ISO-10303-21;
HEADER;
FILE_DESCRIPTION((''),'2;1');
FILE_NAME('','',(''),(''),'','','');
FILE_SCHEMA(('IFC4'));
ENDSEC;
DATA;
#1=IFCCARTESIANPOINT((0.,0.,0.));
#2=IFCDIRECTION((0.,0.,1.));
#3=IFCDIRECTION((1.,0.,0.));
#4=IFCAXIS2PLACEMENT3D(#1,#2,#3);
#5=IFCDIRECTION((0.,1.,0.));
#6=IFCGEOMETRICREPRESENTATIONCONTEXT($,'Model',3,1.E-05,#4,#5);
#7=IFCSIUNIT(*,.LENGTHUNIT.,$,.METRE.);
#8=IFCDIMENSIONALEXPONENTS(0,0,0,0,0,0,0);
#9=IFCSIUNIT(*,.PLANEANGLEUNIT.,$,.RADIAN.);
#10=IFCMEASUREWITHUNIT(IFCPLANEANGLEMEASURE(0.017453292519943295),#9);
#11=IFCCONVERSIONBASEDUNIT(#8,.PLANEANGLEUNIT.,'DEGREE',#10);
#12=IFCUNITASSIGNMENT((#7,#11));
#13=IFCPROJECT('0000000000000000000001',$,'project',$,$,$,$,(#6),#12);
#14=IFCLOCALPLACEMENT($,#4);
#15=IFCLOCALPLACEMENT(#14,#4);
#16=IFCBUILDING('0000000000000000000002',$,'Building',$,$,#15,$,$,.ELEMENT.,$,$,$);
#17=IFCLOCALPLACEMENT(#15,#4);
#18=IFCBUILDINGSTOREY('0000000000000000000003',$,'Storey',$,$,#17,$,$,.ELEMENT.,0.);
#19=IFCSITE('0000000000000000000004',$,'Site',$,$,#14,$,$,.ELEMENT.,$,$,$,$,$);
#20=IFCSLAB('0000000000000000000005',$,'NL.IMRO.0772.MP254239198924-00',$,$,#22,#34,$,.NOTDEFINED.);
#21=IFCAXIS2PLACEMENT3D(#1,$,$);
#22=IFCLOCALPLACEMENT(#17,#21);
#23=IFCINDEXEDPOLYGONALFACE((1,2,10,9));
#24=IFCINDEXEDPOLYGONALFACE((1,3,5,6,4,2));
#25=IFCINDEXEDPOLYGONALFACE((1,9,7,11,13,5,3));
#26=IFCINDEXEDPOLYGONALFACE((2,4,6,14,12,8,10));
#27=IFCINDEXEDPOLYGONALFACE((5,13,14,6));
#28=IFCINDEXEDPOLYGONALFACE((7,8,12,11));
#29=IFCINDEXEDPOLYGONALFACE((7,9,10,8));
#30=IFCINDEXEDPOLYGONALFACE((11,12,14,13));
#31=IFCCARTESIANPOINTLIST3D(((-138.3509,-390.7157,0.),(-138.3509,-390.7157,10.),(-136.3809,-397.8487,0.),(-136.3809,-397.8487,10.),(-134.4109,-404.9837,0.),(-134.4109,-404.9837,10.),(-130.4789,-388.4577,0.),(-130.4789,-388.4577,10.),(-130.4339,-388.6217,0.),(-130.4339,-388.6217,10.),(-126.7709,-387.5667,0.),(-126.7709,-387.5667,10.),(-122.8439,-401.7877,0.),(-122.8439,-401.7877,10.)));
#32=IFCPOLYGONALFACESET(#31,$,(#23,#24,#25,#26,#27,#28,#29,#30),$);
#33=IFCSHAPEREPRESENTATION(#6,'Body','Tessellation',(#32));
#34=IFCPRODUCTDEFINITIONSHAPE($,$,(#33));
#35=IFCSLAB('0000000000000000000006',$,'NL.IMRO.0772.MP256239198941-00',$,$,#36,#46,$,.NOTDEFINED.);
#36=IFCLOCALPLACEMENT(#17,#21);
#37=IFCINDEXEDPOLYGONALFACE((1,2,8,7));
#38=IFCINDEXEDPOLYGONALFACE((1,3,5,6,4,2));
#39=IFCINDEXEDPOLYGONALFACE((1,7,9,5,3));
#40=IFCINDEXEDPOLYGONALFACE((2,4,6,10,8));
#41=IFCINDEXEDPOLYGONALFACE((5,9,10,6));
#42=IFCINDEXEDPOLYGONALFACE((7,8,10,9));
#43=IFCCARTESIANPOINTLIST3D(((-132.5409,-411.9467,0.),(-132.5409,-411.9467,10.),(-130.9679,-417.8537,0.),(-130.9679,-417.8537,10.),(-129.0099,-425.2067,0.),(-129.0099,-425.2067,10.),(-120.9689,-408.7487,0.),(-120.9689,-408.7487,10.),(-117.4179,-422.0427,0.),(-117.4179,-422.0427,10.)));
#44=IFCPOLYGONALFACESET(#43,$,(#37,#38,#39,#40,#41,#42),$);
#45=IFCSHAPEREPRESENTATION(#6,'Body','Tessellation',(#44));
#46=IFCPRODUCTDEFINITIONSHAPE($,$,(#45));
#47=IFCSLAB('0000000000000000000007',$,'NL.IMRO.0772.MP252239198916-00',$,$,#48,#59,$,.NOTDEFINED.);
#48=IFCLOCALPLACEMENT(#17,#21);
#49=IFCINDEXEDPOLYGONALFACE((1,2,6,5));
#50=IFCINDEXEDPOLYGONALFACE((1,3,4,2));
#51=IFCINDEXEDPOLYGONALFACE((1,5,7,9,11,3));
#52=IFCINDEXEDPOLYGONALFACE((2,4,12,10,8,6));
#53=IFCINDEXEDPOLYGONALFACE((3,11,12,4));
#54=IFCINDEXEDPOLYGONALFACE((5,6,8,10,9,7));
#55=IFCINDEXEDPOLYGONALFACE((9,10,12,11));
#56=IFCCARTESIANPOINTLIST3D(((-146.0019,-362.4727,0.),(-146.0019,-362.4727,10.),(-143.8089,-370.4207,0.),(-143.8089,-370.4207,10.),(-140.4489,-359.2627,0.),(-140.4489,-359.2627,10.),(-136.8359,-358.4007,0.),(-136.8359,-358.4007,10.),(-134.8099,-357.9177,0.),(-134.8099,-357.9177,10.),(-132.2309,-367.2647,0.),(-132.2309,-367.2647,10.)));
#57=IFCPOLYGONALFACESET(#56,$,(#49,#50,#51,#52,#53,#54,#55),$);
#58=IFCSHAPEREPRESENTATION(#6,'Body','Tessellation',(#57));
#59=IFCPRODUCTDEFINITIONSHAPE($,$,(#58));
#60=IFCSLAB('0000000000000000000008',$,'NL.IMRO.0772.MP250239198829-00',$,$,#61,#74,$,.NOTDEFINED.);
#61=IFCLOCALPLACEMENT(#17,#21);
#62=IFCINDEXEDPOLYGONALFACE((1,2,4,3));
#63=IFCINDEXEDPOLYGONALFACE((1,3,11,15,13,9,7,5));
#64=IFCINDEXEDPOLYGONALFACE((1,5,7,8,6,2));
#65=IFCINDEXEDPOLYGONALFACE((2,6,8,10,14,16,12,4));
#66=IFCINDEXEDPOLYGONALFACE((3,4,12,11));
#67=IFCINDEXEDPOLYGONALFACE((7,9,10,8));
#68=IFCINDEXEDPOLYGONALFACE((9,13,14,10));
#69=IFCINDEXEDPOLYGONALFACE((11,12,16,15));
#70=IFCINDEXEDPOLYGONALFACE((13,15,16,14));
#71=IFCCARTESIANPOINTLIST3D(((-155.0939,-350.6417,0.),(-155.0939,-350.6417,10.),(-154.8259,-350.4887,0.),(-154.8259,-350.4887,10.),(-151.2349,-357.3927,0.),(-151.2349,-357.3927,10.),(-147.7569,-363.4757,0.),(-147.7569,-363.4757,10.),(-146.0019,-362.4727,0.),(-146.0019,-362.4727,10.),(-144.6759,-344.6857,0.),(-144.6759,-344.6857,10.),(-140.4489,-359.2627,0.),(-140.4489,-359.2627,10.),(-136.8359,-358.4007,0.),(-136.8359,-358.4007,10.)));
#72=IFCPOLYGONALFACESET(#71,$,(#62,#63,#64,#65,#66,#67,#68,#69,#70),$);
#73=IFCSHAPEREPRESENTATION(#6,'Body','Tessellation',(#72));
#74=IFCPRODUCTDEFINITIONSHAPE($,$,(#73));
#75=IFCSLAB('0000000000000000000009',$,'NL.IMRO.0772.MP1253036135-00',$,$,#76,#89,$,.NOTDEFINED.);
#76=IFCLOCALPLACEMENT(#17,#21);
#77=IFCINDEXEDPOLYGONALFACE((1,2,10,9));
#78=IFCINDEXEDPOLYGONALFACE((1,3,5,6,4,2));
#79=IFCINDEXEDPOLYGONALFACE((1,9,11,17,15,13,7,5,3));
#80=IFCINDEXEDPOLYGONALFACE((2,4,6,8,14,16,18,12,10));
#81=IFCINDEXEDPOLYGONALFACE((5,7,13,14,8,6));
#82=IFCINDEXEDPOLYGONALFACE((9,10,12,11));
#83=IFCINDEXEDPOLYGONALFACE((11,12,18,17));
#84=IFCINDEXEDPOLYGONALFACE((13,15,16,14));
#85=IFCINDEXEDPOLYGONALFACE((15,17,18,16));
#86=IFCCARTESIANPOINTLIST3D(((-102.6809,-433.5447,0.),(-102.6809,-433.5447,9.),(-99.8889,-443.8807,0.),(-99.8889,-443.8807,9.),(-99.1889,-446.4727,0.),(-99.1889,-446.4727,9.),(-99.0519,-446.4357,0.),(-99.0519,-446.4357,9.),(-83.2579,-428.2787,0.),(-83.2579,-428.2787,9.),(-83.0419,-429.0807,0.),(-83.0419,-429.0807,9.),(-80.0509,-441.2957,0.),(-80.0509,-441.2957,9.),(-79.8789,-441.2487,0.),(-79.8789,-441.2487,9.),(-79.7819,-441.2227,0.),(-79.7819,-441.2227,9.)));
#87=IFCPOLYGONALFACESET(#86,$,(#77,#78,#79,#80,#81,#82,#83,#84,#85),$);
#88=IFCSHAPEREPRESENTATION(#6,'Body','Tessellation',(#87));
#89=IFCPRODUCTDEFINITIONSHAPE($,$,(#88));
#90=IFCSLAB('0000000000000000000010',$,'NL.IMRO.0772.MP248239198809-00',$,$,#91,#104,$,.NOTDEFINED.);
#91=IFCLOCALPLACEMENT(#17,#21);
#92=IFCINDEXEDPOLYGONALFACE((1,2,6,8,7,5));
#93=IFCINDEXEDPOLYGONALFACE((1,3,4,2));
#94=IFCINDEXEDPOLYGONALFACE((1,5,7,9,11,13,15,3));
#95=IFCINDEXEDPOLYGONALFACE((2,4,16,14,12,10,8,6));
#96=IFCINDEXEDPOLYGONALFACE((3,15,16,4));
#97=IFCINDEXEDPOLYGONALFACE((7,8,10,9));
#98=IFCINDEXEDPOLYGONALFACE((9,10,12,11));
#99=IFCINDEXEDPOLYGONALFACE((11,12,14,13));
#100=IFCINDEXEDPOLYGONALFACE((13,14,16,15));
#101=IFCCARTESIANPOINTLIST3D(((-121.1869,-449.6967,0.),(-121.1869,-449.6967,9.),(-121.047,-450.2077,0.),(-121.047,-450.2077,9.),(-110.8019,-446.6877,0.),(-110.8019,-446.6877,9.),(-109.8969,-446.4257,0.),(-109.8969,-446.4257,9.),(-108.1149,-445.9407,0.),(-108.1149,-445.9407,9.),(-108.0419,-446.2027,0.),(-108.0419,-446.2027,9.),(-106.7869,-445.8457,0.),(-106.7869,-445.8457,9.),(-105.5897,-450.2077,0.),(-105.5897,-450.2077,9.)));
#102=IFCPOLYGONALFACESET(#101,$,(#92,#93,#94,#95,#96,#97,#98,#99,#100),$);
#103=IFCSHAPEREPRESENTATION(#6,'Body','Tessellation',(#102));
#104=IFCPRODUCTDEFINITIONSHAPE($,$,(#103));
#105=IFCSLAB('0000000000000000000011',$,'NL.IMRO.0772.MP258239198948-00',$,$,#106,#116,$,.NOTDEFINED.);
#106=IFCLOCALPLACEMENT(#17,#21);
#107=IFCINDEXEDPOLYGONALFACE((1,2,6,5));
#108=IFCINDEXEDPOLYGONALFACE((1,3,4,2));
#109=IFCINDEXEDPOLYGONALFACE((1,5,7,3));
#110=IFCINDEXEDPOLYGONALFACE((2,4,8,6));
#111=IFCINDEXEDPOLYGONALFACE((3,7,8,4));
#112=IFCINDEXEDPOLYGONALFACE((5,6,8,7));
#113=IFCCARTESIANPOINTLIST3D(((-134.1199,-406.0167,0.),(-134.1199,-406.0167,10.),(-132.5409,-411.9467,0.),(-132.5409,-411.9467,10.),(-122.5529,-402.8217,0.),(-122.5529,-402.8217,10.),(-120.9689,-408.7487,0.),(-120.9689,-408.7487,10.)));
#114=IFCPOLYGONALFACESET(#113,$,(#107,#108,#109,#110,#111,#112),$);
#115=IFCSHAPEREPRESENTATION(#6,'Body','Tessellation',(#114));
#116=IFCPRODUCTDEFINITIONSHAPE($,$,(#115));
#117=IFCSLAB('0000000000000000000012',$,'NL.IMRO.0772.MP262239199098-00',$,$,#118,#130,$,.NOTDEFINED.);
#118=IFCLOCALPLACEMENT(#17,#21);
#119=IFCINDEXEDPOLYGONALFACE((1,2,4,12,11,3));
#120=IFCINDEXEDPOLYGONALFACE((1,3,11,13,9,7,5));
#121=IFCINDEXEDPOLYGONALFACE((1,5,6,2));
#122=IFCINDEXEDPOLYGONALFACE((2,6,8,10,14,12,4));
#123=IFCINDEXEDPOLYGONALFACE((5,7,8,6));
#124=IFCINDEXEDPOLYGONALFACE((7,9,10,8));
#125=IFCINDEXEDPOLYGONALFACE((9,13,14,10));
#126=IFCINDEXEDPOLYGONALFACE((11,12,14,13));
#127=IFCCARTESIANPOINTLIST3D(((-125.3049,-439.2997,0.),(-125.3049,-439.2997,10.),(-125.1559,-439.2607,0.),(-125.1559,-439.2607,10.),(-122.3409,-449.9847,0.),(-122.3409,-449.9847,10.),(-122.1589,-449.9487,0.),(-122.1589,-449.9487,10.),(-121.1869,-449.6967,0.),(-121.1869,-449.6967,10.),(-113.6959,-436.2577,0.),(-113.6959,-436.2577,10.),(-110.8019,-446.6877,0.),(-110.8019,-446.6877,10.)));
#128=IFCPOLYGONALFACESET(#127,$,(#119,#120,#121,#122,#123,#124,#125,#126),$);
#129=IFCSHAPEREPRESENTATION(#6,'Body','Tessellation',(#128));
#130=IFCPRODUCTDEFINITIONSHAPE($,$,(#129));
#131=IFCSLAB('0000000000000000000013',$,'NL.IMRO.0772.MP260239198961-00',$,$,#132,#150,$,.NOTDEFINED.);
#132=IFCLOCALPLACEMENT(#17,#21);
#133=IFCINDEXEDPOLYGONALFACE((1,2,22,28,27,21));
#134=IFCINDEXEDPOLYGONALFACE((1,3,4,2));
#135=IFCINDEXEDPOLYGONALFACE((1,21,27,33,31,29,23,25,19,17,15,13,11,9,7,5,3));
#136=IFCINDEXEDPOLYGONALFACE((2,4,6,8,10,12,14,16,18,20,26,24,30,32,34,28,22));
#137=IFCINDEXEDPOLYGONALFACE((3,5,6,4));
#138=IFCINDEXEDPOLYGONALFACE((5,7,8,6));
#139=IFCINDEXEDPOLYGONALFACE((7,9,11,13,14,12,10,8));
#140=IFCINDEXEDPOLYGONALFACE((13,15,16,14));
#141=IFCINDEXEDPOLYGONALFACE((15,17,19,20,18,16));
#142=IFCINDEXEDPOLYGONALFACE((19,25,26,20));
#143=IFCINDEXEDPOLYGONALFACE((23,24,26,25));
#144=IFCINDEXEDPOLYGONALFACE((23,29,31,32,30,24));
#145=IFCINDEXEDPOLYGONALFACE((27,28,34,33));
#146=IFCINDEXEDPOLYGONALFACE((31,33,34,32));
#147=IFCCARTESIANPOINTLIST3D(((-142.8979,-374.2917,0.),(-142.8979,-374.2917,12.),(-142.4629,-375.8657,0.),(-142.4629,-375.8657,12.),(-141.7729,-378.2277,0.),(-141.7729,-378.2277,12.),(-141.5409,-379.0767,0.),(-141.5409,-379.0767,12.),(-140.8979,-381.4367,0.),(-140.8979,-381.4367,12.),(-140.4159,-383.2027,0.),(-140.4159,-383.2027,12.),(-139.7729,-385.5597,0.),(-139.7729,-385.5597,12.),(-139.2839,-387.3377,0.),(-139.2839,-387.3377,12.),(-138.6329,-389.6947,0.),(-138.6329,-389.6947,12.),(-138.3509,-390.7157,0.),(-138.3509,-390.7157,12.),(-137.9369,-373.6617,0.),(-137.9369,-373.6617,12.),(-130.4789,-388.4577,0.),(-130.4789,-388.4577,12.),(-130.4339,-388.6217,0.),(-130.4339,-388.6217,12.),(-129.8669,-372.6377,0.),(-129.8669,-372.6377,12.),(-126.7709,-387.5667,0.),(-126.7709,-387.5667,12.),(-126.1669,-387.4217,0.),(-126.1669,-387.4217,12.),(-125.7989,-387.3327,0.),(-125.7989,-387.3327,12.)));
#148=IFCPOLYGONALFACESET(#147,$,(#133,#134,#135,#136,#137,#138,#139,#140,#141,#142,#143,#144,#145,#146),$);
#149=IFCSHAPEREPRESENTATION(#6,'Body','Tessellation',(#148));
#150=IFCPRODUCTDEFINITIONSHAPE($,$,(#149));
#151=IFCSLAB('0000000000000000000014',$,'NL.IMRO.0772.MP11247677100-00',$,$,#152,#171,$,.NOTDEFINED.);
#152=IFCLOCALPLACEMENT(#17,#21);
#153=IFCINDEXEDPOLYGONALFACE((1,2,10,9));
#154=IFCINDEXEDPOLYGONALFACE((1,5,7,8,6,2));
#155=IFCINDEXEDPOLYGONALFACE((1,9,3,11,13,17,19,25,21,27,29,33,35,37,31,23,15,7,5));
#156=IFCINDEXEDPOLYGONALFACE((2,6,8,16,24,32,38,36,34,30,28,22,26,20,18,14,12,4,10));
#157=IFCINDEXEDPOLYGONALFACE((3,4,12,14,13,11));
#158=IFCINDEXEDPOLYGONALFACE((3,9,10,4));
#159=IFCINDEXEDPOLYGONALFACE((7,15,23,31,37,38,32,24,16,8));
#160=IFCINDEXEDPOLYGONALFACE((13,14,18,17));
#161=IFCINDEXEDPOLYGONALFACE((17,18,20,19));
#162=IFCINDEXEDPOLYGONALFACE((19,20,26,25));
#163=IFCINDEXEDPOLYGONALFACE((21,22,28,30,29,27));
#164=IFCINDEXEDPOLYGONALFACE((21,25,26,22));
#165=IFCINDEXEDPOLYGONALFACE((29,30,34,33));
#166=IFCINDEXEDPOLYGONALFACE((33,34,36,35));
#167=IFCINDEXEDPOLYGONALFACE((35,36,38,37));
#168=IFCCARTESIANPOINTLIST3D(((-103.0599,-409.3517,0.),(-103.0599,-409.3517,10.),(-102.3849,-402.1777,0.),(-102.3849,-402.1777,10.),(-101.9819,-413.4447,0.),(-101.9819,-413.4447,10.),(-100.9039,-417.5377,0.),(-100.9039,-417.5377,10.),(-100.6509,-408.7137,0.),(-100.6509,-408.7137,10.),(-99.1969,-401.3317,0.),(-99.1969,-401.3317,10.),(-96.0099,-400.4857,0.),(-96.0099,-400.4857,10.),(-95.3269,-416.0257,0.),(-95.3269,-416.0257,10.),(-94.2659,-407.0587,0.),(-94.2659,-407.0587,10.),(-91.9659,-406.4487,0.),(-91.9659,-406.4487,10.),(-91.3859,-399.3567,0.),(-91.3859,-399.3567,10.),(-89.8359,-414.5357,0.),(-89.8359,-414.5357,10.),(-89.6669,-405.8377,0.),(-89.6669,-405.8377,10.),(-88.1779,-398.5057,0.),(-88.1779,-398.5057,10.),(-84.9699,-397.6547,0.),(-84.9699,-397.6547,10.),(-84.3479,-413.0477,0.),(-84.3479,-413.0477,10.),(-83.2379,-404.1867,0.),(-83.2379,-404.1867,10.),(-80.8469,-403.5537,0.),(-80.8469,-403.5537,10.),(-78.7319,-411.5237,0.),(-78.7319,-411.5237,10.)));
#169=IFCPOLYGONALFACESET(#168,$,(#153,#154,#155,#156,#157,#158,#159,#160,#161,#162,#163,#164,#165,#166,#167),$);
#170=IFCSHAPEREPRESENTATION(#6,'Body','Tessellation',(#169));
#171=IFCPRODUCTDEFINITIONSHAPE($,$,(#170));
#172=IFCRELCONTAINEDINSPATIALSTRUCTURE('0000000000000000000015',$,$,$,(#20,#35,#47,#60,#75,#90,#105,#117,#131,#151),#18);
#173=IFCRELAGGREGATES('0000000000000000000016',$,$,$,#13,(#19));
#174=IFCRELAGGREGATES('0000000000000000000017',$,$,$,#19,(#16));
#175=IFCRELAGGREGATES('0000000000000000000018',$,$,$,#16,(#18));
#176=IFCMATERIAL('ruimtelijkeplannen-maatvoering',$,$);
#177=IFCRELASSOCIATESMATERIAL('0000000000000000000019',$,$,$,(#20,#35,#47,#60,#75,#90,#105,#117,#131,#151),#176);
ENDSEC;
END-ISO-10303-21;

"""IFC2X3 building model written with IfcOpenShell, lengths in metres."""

from ifc_helpers import new_model, entity, si_unit, converted_unit, direction, origin_with_axes, place, context, project, spatial, polyline, outline, extrude, material, element, save


model = new_model("IFC2X3")

# Units and contexts
model_context = context("Model", 3, precision=1e-05, world=origin_with_axes(), true_north=direction((0.0, 1.0, 0.0)))
ifc_project = project(units=[si_unit("LENGTHUNIT", "METRE"), converted_unit("PLANEANGLEUNIT", "DEGREE", entity("IfcPlaneAngleMeasure", 0.017453292519943295), si_unit("PLANEANGLEUNIT", "RADIAN"), dimensions=[0, 0, 0, 0, 0, 0, 0])], contexts=[model_context])

# Site, building, storey
site_placement = place(None, origin_with_axes())
site = spatial("IfcSite", under=ifc_project, at=site_placement, Name="Site", CompositionType="ELEMENT")
building_placement = place(site_placement, origin_with_axes())
building = spatial("IfcBuilding", under=site, at=building_placement, Name="Building", CompositionType="ELEMENT")
storey_placement = place(building_placement, origin_with_axes())
storey = spatial("IfcBuildingStorey", under=building, at=storey_placement, Name="Storey", CompositionType="ELEMENT", Elevation=0.0)

# Slabs
ifc_material_1 = material(Name="ruimtelijkeplannen-maatvoering")
slab_1_placement = place(storey_placement, origin_with_axes())
element("IfcSlab", 1, at=slab_1_placement, inside=storey, material=ifc_material_1, Name="NL.IMRO.0772.MP254239198924-00", PredefinedType="NOTDEFINED", context=model_context, shape_type="SweptSolid", body=[
    extrude(outline(polyline([(-134.4109, -404.9837), (-136.3809, -397.8487), (-138.3509, -390.7157), (-130.4339, -388.6217), (-130.4789, -388.4577), (-126.7709, -387.5667), (-122.8439, -401.7877), (-134.4109, -404.9837)])), origin_with_axes(), (0.0, 0.0, 1.0), 10.0),
])
slab_2_placement = place(storey_placement, origin_with_axes())
element("IfcSlab", 2, at=slab_2_placement, inside=storey, material=ifc_material_1, Name="NL.IMRO.0772.MP256239198941-00", PredefinedType="NOTDEFINED", context=model_context, shape_type="SweptSolid", body=[
    extrude(outline(polyline([(-117.4179, -422.0427), (-129.0099, -425.2067), (-130.9679, -417.8537), (-132.5409, -411.9467), (-120.9689, -408.7487), (-117.4179, -422.0427)])), origin_with_axes(), (0.0, 0.0, 1.0), 10.0),
])
slab_3_placement = place(storey_placement, origin_with_axes())
element("IfcSlab", 3, at=slab_3_placement, inside=storey, material=ifc_material_1, Name="NL.IMRO.0772.MP252239198916-00", PredefinedType="NOTDEFINED", context=model_context, shape_type="SweptSolid", body=[
    extrude(outline(polyline([(-136.8359, -358.4007), (-134.8099, -357.9177), (-132.2309, -367.2647), (-143.8089, -370.4207), (-146.0019, -362.4727), (-140.4489, -359.2627), (-136.8359, -358.4007)])), origin_with_axes(), (0.0, 0.0, 1.0), 10.0),
])
slab_4_placement = place(storey_placement, origin_with_axes())
element("IfcSlab", 4, at=slab_4_placement, inside=storey, material=ifc_material_1, Name="NL.IMRO.0772.MP250239198829-00", PredefinedType="NOTDEFINED", context=model_context, shape_type="SweptSolid", body=[
    extrude(outline(polyline([(-144.6759, -344.6857), (-136.8359, -358.4007), (-140.4489, -359.2627), (-146.0019, -362.4727), (-147.7569, -363.4757), (-151.2349, -357.3927), (-155.0939, -350.6417), (-154.8259, -350.4887), (-144.6759, -344.6857)])), origin_with_axes(), (0.0, 0.0, 1.0), 10.0),
])
slab_5_placement = place(storey_placement, origin_with_axes())
element("IfcSlab", 5, at=slab_5_placement, inside=storey, material=ifc_material_1, Name="NL.IMRO.0772.MP1253036135-00", PredefinedType="NOTDEFINED", context=model_context, shape_type="SweptSolid", body=[
    extrude(outline(polyline([(-79.8789, -441.2487), (-80.0509, -441.2957), (-99.0519, -446.4357), (-99.1889, -446.4727), (-99.8889, -443.8807), (-102.6809, -433.5447), (-83.2579, -428.2787), (-83.0419, -429.0807), (-79.7819, -441.2227), (-79.8789, -441.2487)])), origin_with_axes(), (0.0, 0.0, 1.0), 9.0),
])
slab_6_placement = place(storey_placement, origin_with_axes())
element("IfcSlab", 6, at=slab_6_placement, inside=storey, material=ifc_material_1, Name="NL.IMRO.0772.MP248239198809-00", PredefinedType="NOTDEFINED", context=model_context, shape_type="SweptSolid", body=[
    extrude(outline(polyline([(-121.1869, -449.6967), (-110.8019, -446.6877), (-109.8969, -446.4257), (-108.1149, -445.9407), (-108.0419, -446.2027), (-106.7869, -445.8457), (-105.5897, -450.2077), (-121.047, -450.2077), (-121.1869, -449.6967)])), origin_with_axes(), (0.0, 0.0, 1.0), 9.0),
])
slab_7_placement = place(storey_placement, origin_with_axes())
element("IfcSlab", 7, at=slab_7_placement, inside=storey, material=ifc_material_1, Name="NL.IMRO.0772.MP258239198948-00", PredefinedType="NOTDEFINED", context=model_context, shape_type="SweptSolid", body=[
    extrude(outline(polyline([(-122.5529, -402.8217), (-120.9689, -408.7487), (-132.5409, -411.9467), (-134.1199, -406.0167), (-122.5529, -402.8217)])), origin_with_axes(), (0.0, 0.0, 1.0), 10.0),
])
slab_8_placement = place(storey_placement, origin_with_axes())
element("IfcSlab", 8, at=slab_8_placement, inside=storey, material=ifc_material_1, Name="NL.IMRO.0772.MP262239199098-00", PredefinedType="NOTDEFINED", context=model_context, shape_type="SweptSolid", body=[
    extrude(outline(polyline([(-121.1869, -449.6967), (-122.1589, -449.9487), (-122.3409, -449.9847), (-125.3049, -439.2997), (-125.1559, -439.2607), (-113.6959, -436.2577), (-110.8019, -446.6877), (-121.1869, -449.6967)])), origin_with_axes(), (0.0, 0.0, 1.0), 10.0),
])
slab_9_placement = place(storey_placement, origin_with_axes())
element("IfcSlab", 9, at=slab_9_placement, inside=storey, material=ifc_material_1, Name="NL.IMRO.0772.MP260239198961-00", PredefinedType="NOTDEFINED", context=model_context, shape_type="SweptSolid", body=[
    extrude(outline(polyline([(-130.4789, -388.4577), (-130.4339, -388.6217), (-138.3509, -390.7157), (-138.6329, -389.6947), (-139.2839, -387.3377), (-139.7729, -385.5597), (-140.4159, -383.2027), (-140.8979, -381.4367), (-141.5409, -379.0767), (-141.7729, -378.2277), (-142.4629, -375.8657), (-142.8979, -374.2917), (-137.9369, -373.6617), (-129.8669, -372.6377), (-125.7989, -387.3327), (-126.1669, -387.4217), (-126.7709, -387.5667), (-130.4789, -388.4577)])), origin_with_axes(), (0.0, 0.0, 1.0), 12.0),
])
slab_10_placement = place(storey_placement, origin_with_axes())
element("IfcSlab", 10, at=slab_10_placement, inside=storey, material=ifc_material_1, Name="NL.IMRO.0772.MP11247677100-00", PredefinedType="NOTDEFINED", context=model_context, shape_type="SweptSolid", body=[
    extrude(outline(polyline([(-100.6509, -408.7137), (-102.3849, -402.1777), (-99.1969, -401.3317), (-96.0099, -400.4857), (-94.2659, -407.0587), (-91.9659, -406.4487), (-89.6669, -405.8377), (-91.3859, -399.3567), (-88.1779, -398.5057), (-84.9699, -397.6547), (-83.2379, -404.1867), (-80.8469, -403.5537), (-78.7319, -411.5237), (-84.3479, -413.0477), (-89.8359, -414.5357), (-95.3269, -416.0257), (-100.9039, -417.5377), (-101.9819, -413.4447), (-103.0599, -409.3517), (-100.6509, -408.7137)])), origin_with_axes(), (0.0, 0.0, 1.0), 10.0),
])

save(model, "model.ifc")
